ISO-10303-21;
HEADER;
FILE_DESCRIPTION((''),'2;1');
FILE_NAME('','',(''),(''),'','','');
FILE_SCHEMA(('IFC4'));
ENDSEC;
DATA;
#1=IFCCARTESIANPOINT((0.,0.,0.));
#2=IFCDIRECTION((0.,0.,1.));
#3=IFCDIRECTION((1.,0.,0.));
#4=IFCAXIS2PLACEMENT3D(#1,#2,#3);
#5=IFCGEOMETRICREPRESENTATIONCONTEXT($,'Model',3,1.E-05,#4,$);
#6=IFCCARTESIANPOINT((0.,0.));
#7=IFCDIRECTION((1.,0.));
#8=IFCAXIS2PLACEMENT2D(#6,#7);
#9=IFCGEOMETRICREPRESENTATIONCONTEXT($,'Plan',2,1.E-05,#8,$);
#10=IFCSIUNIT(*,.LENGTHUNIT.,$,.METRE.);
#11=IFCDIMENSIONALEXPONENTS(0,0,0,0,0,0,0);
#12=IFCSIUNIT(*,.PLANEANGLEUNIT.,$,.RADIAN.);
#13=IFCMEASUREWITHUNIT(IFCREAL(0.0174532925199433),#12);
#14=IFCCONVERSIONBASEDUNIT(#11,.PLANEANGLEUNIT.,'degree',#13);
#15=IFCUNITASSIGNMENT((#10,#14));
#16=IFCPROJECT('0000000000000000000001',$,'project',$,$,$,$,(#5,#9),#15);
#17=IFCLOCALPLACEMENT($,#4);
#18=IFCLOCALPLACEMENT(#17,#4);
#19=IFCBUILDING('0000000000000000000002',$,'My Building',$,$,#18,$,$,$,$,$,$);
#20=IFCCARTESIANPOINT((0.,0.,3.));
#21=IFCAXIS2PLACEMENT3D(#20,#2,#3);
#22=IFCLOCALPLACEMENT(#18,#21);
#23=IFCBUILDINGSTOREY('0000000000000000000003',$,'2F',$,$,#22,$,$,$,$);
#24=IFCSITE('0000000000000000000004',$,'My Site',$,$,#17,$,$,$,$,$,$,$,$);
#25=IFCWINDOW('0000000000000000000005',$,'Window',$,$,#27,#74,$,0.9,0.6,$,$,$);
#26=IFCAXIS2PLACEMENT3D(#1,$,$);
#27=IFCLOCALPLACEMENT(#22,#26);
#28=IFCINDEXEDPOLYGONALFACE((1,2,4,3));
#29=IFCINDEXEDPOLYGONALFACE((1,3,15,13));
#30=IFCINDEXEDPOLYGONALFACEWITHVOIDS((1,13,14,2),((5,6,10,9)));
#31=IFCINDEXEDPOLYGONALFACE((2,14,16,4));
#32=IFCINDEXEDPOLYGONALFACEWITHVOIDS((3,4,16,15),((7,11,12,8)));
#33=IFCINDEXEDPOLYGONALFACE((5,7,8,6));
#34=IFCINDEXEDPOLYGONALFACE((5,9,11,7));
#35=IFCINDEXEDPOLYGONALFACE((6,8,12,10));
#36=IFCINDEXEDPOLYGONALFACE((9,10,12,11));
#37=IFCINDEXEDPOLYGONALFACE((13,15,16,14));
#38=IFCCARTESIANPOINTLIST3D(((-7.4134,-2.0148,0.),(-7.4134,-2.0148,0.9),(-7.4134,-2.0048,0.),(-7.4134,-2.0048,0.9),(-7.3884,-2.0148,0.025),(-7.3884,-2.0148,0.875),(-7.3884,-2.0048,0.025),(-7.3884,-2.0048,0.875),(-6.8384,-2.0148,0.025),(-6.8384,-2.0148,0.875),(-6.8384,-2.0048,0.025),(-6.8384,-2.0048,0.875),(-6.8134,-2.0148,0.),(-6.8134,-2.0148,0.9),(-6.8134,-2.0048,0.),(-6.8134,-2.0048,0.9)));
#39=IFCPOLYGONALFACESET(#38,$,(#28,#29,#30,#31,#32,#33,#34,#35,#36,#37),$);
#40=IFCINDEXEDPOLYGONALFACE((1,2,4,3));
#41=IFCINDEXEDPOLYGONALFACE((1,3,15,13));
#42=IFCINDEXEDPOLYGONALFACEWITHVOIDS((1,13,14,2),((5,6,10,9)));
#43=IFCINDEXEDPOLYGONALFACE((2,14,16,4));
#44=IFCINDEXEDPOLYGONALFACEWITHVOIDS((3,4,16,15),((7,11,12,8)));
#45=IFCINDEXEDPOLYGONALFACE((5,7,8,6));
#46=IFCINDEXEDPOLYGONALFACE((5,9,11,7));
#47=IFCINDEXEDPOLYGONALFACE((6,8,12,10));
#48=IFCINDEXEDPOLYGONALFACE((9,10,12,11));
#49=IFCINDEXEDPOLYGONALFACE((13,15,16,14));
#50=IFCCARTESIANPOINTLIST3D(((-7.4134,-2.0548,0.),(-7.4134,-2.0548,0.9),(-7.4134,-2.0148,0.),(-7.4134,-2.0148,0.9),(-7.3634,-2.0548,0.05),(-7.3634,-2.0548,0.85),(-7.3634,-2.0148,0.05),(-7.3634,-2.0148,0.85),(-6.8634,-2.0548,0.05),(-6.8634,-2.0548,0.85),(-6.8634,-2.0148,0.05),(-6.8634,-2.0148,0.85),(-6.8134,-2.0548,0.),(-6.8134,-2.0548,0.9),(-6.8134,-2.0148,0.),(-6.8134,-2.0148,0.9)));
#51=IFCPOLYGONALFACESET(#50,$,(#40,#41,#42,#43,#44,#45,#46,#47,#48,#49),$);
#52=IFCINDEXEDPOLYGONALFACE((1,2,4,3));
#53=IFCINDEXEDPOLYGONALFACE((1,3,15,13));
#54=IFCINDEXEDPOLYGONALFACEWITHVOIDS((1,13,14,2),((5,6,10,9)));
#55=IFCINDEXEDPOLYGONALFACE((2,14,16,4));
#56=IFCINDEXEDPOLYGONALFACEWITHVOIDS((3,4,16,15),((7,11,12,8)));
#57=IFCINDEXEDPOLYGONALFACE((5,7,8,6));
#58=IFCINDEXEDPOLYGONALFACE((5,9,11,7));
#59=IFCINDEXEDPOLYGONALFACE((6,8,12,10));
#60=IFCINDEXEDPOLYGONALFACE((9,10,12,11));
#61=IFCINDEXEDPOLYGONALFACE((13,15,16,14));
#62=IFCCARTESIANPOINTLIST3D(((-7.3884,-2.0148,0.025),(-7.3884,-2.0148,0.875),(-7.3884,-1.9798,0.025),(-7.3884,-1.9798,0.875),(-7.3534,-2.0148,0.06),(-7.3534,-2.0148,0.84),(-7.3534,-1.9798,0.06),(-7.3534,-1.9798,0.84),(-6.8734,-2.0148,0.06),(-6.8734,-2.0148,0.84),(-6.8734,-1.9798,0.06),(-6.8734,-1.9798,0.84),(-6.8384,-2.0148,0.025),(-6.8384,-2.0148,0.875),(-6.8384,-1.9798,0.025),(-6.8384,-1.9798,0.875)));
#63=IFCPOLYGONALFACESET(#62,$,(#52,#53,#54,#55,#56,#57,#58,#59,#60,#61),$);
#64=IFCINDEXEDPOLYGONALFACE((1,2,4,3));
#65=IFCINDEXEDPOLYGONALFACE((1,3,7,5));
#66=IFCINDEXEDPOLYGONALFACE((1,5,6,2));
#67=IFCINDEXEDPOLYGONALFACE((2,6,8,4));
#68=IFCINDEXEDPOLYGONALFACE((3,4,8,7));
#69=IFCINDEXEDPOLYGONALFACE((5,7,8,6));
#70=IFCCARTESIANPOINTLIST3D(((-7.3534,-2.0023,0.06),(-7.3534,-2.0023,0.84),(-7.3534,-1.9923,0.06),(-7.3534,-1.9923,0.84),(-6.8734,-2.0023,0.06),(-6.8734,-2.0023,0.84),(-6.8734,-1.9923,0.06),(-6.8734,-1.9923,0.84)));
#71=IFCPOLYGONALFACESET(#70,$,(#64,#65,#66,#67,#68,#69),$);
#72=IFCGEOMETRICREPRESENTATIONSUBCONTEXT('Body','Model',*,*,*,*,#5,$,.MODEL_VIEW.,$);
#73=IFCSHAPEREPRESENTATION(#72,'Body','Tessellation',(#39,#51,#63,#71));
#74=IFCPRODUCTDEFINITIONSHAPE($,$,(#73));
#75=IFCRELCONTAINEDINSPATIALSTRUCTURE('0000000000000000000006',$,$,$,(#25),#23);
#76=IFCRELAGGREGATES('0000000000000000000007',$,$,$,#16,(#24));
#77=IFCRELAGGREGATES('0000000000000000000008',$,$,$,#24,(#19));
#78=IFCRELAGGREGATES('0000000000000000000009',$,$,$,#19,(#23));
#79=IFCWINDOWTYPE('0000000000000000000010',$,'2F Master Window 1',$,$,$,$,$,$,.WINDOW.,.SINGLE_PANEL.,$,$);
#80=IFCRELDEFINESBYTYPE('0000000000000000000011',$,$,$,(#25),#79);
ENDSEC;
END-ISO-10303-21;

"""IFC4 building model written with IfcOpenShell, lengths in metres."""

from ifc_helpers import new_model, entity, si_unit, converted_unit, frame, origin_with_axes, origin_2d_with_axis, place, context, subcontext, project, spatial, line, indexed_curve, outline, extrude, shape, source, transform, mapped, type_object, type_shapes, element, save


model = new_model("IFC4")

# Units and contexts
model_context = context("Model", 3, precision=1e-05, world=origin_with_axes())
plan_context = context("Plan", 2, precision=1e-05, world=origin_2d_with_axis())
body_context_1 = subcontext(model_context, "Body", "Model", "MODEL_VIEW")
body_context_2 = subcontext(plan_context, "Body", "Plan", "PLAN_VIEW")
ifc_project = project(units=[si_unit("LENGTHUNIT", "METRE"), converted_unit("PLANEANGLEUNIT", "degree", entity("IfcReal", 0.0174532925199433), si_unit("PLANEANGLEUNIT", "RADIAN"), dimensions=[0, 0, 0, 0, 0, 0, 0])], contexts=[model_context, plan_context])

# Site, building, storey
site_placement = place(None, origin_with_axes())
site = spatial("IfcSite", under=ifc_project, at=site_placement, Name="My Site")
building_placement = place(site_placement, origin_with_axes())
building = spatial("IfcBuilding", under=site, at=building_placement, Name="My Building")
storey_placement = place(building_placement, frame((0.0, 0.0, 3.0), z_axis=(0.0, 0.0, 1.0), x_axis=(1.0, 0.0, 0.0)))
storey = spatial("IfcBuildingStorey", under=building, at=storey_placement, Name="2F")

# Window
window_type_1 = type_object("IfcWindowType", Name="2F Master Window 1", PartitioningType="SINGLE_PANEL", PredefinedType="WINDOW")
shared_shape_1 = source(origin_with_axes(), body_context_1, "Body", "SweptSolid", [
    extrude(outline(indexed_curve([(0.0, 0.0), (0.6, 0.0), (0.6, 0.9), (0.0, 0.9)], segments=[line(1, 2, 3, 4, 1)]), holes=[indexed_curve([(0.025, 0.025), (0.575, 0.025), (0.575, 0.875), (0.025, 0.875)], segments=[line(1, 2, 3, 4, 1)])]), frame((0.0, 0.09, 0.0), z_axis=(0.0, -1.0, 0.0), x_axis=(1.0, 0.0, 0.0)), (0.0, 0.0, -1.0), 0.01),
    extrude(outline(indexed_curve([(0.0, 0.0), (0.6, 0.0), (0.6, 0.9), (0.0, 0.9)], segments=[line(1, 2, 3, 4, 1)]), holes=[indexed_curve([(0.05, 0.05), (0.55, 0.05), (0.55, 0.85), (0.05, 0.85)], segments=[line(1, 2, 3, 4, 1)])]), frame((0.0, 0.05, 0.0), z_axis=(0.0, -1.0, 0.0), x_axis=(1.0, 0.0, 0.0)), (0.0, 0.0, -1.0), 0.04),
    extrude(outline(indexed_curve([(0.0, 0.0), (0.55, 0.0), (0.55, 0.85), (0.0, 0.85)], segments=[line(1, 2, 3, 4, 1)]), holes=[indexed_curve([(0.035, 0.035), (0.515, 0.035), (0.515, 0.815), (0.035, 0.815)], segments=[line(1, 2, 3, 4, 1)])]), frame((0.025, 0.09, 0.025), z_axis=(0.0, -1.0, 0.0), x_axis=(1.0, 0.0, 0.0)), (0.0, 0.0, -1.0), 0.035),
    extrude(outline(indexed_curve([(0.035, 0.035), (0.515, 0.035), (0.515, 0.815), (0.035, 0.815)], segments=[line(1, 2, 3, 4, 1)])), frame((0.025, 0.1025, 0.025), z_axis=(0.0, -1.0, 0.0), x_axis=(1.0, 0.0, 0.0)), (0.0, 0.0, -1.0), 0.01),
])
shared_shape_2 = source(origin_with_axes(), body_context_2, "Body", "Curve2D", [
    entity("IfcIndexedPolyCurve", entity("IfcCartesianPointList2D", [[0.05, 0.05], [0.55, 0.05]])),
    entity("IfcIndexedPolyCurve", entity("IfcCartesianPointList2D", [[0.0, 0.1], [0.025, 0.1], [0.025, 0.09], [0.05, 0.09], [0.05, 0.05], [0.0, 0.05]]), [entity("IfcLineIndex", [1, 2, 3, 4, 5, 6, 1])]),
    entity("IfcIndexedPolyCurve", entity("IfcCartesianPointList2D", [[0.6, 0.1], [0.575, 0.1], [0.575, 0.09], [0.55, 0.09], [0.55, 0.05], [0.6, 0.05]]), [entity("IfcLineIndex", [1, 2, 3, 4, 5, 6, 1])]),
    entity("IfcIndexedPolyCurve", entity("IfcCartesianPointList2D", [[0.025, 0.09], [0.06, 0.09], [0.06, 0.125], [0.025, 0.125]]), [entity("IfcLineIndex", [1, 2, 3, 4, 1])]),
    entity("IfcIndexedPolyCurve", entity("IfcCartesianPointList2D", [[0.575, 0.09], [0.54, 0.09], [0.54, 0.125], [0.575, 0.125]]), [entity("IfcLineIndex", [1, 2, 3, 4, 1])]),
    entity("IfcIndexedPolyCurve", entity("IfcCartesianPointList2D", [[0.06, 0.09], [0.54, 0.09]])),
    entity("IfcIndexedPolyCurve", entity("IfcCartesianPointList2D", [[0.06, 0.125], [0.54, 0.125]])),
    entity("IfcIndexedPolyCurve", entity("IfcCartesianPointList2D", [[0.06, 0.1075], [0.54, 0.1075]])),
])
type_shapes(window_type_1, [shared_shape_1, shared_shape_2])
window_1_placement = place(storey_placement, frame((-7.4134, -2.1048, 0.0), z_axis=(0.0, 0.0, 1.0), x_axis=(1.0, 0.0, 0.0)))
element("IfcWindow", 1, at=window_1_placement, inside=storey, type_object=window_type_1, Name="Window", OverallHeight=0.9, OverallWidth=0.6, shapes=[
    shape(body_context_1, "Body", "MappedRepresentation", [mapped(shared_shape_1, transform((0.0, 0.0, 0.0), x_axis=(1.0, 0.0, 0.0), y_axis=(0.0, 1.0, 0.0), z_axis=(0.0, 0.0, 1.0), scale=1.0))]),
    shape(body_context_2, "Body", "MappedRepresentation", [mapped(shared_shape_2, transform((0.0, 0.0, 0.0), x_axis=(1.0, 0.0, 0.0), y_axis=(0.0, 1.0, 0.0), z_axis=(0.0, 0.0, 1.0), scale=1.0))]),
])

save(model, "model.ifc")
